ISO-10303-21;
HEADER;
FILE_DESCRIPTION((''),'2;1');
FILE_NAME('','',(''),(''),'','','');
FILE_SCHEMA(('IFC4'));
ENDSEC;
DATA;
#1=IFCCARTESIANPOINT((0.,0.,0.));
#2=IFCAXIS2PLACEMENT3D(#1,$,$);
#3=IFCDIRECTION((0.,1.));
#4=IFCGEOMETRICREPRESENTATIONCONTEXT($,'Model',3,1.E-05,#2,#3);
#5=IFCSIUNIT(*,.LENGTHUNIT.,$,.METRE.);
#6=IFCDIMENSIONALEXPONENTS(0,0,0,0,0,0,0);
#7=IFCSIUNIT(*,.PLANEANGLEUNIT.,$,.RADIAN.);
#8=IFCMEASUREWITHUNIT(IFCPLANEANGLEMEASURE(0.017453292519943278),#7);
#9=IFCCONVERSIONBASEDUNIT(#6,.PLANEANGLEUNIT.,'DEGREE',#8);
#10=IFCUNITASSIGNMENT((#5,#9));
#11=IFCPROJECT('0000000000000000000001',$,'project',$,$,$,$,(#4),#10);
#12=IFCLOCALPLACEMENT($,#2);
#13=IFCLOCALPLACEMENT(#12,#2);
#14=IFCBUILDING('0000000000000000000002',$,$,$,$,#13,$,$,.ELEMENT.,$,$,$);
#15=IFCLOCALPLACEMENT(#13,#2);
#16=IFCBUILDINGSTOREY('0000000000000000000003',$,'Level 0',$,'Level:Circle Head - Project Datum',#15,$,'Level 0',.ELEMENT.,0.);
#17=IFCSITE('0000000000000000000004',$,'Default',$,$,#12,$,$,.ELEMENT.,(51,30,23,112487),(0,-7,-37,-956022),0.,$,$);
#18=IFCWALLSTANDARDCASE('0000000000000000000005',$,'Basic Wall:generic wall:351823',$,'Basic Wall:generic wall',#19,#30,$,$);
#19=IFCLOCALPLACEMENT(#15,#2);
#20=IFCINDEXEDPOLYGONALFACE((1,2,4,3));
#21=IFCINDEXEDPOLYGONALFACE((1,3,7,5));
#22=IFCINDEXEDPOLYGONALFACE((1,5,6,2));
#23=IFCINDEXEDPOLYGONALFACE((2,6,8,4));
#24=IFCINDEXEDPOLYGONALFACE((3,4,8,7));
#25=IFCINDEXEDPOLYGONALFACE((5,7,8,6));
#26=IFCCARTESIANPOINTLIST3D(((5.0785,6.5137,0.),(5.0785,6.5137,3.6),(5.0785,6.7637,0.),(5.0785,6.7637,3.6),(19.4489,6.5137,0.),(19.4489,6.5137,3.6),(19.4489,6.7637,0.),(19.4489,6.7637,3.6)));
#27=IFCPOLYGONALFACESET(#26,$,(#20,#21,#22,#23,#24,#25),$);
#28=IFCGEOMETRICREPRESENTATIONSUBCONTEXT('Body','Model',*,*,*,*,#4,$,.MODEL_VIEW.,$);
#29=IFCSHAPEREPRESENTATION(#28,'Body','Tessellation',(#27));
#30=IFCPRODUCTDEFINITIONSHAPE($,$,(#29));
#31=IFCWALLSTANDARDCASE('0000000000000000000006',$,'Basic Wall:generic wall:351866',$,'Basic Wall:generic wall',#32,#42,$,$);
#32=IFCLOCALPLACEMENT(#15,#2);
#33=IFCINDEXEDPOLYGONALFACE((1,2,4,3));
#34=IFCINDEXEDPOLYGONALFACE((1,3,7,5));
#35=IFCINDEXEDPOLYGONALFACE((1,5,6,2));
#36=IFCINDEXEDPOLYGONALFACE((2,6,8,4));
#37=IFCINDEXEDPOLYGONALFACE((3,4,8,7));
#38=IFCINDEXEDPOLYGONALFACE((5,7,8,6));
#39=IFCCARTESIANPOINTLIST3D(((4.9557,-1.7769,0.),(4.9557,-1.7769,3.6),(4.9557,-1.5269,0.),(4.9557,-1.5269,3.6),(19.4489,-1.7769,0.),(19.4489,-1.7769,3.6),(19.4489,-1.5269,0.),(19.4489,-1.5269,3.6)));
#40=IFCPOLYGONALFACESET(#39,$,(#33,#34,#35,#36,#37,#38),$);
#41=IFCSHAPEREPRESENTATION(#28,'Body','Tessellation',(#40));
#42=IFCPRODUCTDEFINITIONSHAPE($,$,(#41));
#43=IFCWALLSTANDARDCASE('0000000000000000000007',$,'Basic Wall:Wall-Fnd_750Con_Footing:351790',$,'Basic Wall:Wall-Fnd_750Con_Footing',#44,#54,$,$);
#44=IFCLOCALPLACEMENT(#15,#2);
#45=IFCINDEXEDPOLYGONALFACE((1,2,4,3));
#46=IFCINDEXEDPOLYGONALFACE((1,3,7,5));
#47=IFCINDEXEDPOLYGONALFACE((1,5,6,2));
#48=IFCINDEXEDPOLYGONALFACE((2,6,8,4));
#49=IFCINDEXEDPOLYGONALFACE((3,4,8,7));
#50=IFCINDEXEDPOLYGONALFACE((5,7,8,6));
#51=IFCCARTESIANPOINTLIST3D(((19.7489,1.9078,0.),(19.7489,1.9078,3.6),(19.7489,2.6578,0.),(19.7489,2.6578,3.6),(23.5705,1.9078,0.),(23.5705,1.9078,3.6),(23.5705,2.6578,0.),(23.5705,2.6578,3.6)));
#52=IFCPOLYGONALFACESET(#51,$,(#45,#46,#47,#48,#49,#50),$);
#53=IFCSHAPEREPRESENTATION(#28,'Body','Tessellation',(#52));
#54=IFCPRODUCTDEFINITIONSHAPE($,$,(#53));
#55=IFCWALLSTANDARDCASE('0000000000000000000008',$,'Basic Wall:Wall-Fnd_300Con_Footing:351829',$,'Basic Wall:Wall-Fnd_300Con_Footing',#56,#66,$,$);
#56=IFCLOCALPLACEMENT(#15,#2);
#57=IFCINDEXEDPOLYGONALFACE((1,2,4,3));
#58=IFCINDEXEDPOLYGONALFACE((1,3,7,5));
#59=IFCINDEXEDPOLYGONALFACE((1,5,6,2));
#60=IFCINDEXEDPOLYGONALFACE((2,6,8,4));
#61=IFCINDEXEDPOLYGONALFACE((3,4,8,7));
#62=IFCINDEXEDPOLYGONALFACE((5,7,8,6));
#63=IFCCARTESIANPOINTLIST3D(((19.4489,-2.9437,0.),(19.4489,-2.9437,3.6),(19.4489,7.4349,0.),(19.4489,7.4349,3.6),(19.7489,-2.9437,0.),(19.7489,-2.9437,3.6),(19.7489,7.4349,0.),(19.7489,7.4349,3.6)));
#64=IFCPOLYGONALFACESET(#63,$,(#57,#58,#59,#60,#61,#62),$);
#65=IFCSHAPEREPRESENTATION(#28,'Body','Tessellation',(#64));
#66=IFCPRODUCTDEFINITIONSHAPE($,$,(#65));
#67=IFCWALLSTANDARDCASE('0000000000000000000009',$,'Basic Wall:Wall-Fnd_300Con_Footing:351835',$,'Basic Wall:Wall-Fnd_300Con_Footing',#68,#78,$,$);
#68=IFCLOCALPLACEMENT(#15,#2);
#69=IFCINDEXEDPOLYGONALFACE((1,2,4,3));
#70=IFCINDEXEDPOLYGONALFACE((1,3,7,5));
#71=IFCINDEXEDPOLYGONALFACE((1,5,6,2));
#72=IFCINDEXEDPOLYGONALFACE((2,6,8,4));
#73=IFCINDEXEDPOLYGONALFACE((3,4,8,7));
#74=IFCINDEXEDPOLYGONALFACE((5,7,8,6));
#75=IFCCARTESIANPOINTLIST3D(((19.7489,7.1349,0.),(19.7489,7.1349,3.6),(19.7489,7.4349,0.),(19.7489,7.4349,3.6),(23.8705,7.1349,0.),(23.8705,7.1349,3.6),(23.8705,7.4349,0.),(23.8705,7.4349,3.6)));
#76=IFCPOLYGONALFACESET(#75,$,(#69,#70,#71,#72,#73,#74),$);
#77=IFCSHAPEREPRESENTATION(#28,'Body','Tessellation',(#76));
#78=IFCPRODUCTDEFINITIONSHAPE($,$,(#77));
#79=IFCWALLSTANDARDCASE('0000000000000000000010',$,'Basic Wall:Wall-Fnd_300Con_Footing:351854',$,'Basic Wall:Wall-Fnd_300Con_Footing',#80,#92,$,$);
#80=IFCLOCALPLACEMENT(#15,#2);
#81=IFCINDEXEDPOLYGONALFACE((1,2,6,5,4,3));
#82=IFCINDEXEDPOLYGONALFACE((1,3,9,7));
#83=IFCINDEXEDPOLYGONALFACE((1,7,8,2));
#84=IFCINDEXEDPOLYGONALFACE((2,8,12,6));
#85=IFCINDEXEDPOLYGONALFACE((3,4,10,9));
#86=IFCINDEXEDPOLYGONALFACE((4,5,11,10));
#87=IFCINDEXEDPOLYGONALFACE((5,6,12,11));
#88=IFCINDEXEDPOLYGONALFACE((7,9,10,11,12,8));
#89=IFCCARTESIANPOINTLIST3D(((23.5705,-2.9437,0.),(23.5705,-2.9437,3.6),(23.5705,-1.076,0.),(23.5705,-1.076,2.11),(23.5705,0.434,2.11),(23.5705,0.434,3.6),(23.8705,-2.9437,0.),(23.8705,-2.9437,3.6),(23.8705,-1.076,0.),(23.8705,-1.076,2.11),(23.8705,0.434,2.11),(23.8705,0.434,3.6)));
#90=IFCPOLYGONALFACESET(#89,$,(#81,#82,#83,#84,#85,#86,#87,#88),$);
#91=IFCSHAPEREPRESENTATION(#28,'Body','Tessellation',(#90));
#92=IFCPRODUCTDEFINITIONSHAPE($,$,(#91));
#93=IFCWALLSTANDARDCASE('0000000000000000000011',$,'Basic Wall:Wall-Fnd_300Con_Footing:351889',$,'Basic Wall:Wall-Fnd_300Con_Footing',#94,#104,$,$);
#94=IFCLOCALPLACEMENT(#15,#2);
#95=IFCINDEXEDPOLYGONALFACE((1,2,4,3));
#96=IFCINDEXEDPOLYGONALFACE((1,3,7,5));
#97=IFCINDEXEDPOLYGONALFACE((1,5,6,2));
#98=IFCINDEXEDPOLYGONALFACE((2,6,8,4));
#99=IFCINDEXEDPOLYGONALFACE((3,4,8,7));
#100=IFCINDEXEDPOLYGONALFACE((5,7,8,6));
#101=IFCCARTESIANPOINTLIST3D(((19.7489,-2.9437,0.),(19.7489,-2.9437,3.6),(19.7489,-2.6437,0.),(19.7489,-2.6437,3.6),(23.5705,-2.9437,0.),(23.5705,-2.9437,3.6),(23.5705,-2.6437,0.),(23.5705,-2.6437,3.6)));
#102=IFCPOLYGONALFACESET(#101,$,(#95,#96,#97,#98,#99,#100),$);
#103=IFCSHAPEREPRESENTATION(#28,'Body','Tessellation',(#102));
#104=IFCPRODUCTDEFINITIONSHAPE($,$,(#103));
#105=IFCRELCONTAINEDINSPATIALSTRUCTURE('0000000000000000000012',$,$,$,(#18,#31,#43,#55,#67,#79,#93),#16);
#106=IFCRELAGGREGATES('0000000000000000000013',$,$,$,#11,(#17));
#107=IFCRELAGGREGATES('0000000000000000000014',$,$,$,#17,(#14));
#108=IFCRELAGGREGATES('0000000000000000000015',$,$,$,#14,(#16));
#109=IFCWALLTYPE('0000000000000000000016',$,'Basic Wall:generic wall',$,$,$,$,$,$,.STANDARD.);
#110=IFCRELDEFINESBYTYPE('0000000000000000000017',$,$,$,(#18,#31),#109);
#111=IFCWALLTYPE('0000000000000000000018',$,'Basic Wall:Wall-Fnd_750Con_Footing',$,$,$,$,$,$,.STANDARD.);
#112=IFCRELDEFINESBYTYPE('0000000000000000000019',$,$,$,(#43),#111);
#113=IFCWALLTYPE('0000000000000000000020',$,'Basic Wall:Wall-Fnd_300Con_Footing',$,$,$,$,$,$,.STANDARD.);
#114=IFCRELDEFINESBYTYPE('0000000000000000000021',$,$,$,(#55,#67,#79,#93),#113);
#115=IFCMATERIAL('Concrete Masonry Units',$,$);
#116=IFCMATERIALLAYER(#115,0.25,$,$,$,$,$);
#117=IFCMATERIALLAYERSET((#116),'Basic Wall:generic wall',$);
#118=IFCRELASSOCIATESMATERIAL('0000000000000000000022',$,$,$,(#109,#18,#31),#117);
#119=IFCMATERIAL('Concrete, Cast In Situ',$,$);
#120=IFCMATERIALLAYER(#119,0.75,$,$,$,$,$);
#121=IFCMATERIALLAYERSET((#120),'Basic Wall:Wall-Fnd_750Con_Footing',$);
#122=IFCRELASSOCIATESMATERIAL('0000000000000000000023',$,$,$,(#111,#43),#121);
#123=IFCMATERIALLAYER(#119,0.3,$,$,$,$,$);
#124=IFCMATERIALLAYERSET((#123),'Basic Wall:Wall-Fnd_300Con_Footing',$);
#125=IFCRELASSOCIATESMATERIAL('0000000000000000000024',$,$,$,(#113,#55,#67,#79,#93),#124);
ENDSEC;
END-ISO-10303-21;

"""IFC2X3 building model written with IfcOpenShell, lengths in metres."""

from ifc_helpers import new_model, entity, si_unit, converted_unit, direction, frame, frame_2d, origin, place, context, subcontext, project, spatial, rectangle, extrude, material, layer, layer_set, layer_usage, type_object, element, save


model = new_model("IFC2X3")

# Units and contexts
model_context = context("Model", 3, precision=1e-05, world=origin(), true_north=direction((0.0, 1.0)))
body_context = subcontext(model_context, "Body", "Model", "MODEL_VIEW")
ifc_project = project(units=[si_unit("LENGTHUNIT", "METRE"), converted_unit("PLANEANGLEUNIT", "DEGREE", entity("IfcPlaneAngleMeasure", 0.017453292519943278), si_unit("PLANEANGLEUNIT", "RADIAN"), dimensions=[0, 0, 0, 0, 0, 0, 0])], contexts=[model_context])

# Site, building, storey
site_placement = place(None, origin())
site = spatial("IfcSite", under=ifc_project, at=site_placement, Name="Default", CompositionType="ELEMENT", RefLatitude=(51, 30, 23, 112487), RefLongitude=(0, -7, -37, -956022), RefElevation=0.0)
building_placement = place(site_placement, origin())
building = spatial("IfcBuilding", under=site, at=building_placement, CompositionType="ELEMENT")
storey_placement = place(building_placement, origin())
storey = spatial("IfcBuildingStorey", under=building, at=storey_placement, Name="Level 0", ObjectType="Level:Circle Head - Project Datum", LongName="Level 0", CompositionType="ELEMENT", Elevation=0.0)

# Walls
ifc_material_1 = material(Name="Concrete Masonry Units")
ifc_layer_1 = layer(ifc_material_1, 0.25)
ifc_layer_set_1 = layer_set([ifc_layer_1], Name="Basic Wall:generic wall")
ifc_layer_usage_1 = layer_usage(ifc_layer_set_1, "AXIS2", "NEGATIVE", 0.125)
wall_type_1 = type_object("IfcWallType", Name="Basic Wall:generic wall", PredefinedType="STANDARD", material=ifc_layer_set_1)
wall_1_placement = place(storey_placement, frame((19.4489, 6.6387, 0.0), z_axis=(0.0, 0.0, 1.0), x_axis=(-1.0, 0.0, 0.0)))
element("IfcWallStandardCase", 1, at=wall_1_placement, inside=storey, type_object=wall_type_1, material=ifc_layer_usage_1, Name="Basic Wall:generic wall:351823", ObjectType="Basic Wall:generic wall", context=body_context, shape_type="SweptSolid", body=[
    extrude(rectangle(XDim=14.3703, YDim=0.25, at=frame_2d((7.1852, 0.0), x_axis=(-1.0, 0.0))), origin(), (0.0, 0.0, 1.0), 3.6),
])
ifc_layer_usage_2 = layer_usage(ifc_layer_set_1, "AXIS2", "NEGATIVE", 0.125)
wall_2_placement = place(storey_placement, frame((19.4489, -1.6519, 0.0), z_axis=(0.0, 0.0, 1.0), x_axis=(-1.0, 0.0, 0.0)))
element("IfcWallStandardCase", 2, at=wall_2_placement, inside=storey, type_object=wall_type_1, material=ifc_layer_usage_2, Name="Basic Wall:generic wall:351866", ObjectType="Basic Wall:generic wall", context=body_context, shape_type="SweptSolid", body=[
    extrude(rectangle(XDim=14.4932, YDim=0.25, at=frame_2d((7.2466, 0.0), x_axis=(-1.0, 0.0))), origin(), (0.0, 0.0, 1.0), 3.6),
])
ifc_material_2 = material(Name="Concrete, Cast In Situ")
ifc_layer_2 = layer(ifc_material_2, 0.75)
ifc_layer_set_2 = layer_set([ifc_layer_2], Name="Basic Wall:Wall-Fnd_750Con_Footing")
ifc_layer_usage_3 = layer_usage(ifc_layer_set_2, "AXIS2", "NEGATIVE", 0.375)
wall_type_2 = type_object("IfcWallType", Name="Basic Wall:Wall-Fnd_750Con_Footing", PredefinedType="STANDARD", material=ifc_layer_set_2)
wall_3_placement = place(storey_placement, frame((23.5705, 2.2828, 0.0), z_axis=(0.0, 0.0, 1.0), x_axis=(-1.0, 0.0, 0.0)))
element("IfcWallStandardCase", 3, at=wall_3_placement, inside=storey, type_object=wall_type_2, material=ifc_layer_usage_3, Name="Basic Wall:Wall-Fnd_750Con_Footing:351790", ObjectType="Basic Wall:Wall-Fnd_750Con_Footing", context=body_context, shape_type="SweptSolid", body=[
    extrude(rectangle(XDim=3.8216, YDim=0.75, at=frame_2d((1.9108, 0.0), x_axis=(-1.0, 0.0))), origin(), (0.0, 0.0, 1.0), 3.6),
])
ifc_layer_3 = layer(ifc_material_2, 0.3)
ifc_layer_set_3 = layer_set([ifc_layer_3], Name="Basic Wall:Wall-Fnd_300Con_Footing")
ifc_layer_usage_4 = layer_usage(ifc_layer_set_3, "AXIS2", "NEGATIVE", 0.15)
wall_type_3 = type_object("IfcWallType", Name="Basic Wall:Wall-Fnd_300Con_Footing", PredefinedType="STANDARD", material=ifc_layer_set_3)
wall_4_placement = place(storey_placement, frame((19.5989, -2.9437, 0.0), z_axis=(0.0, 0.0, 1.0), x_axis=(0.0, 1.0, 0.0)))
element("IfcWallStandardCase", 4, at=wall_4_placement, inside=storey, type_object=wall_type_3, material=ifc_layer_usage_4, Name="Basic Wall:Wall-Fnd_300Con_Footing:351829", ObjectType="Basic Wall:Wall-Fnd_300Con_Footing", context=body_context, shape_type="SweptSolid", body=[
    extrude(rectangle(XDim=10.3786, YDim=0.3, at=frame_2d((5.1893, 0.0), x_axis=(-1.0, 0.0))), origin(), (0.0, 0.0, 1.0), 3.6),
])
ifc_layer_usage_5 = layer_usage(ifc_layer_set_3, "AXIS2", "NEGATIVE", 0.15)
wall_5_placement = place(storey_placement, frame((19.7489, 7.2849, 0.0)))
element("IfcWallStandardCase", 5, at=wall_5_placement, inside=storey, type_object=wall_type_3, material=ifc_layer_usage_5, Name="Basic Wall:Wall-Fnd_300Con_Footing:351835", ObjectType="Basic Wall:Wall-Fnd_300Con_Footing", context=body_context, shape_type="SweptSolid", body=[
    extrude(rectangle(XDim=4.1216, YDim=0.3, at=frame_2d((2.0608, 0.0), x_axis=(-1.0, 0.0))), origin(), (0.0, 0.0, 1.0), 3.6),
])

# Wall, opening
ifc_layer_usage_6 = layer_usage(ifc_layer_set_3, "AXIS2", "NEGATIVE", 0.15)
wall_6_placement = place(storey_placement, frame((23.7205, 0.434, 0.0), z_axis=(0.0, 0.0, 1.0), x_axis=(0.0, -1.0, 0.0)))
wall_6 = element("IfcWallStandardCase", 6, at=wall_6_placement, inside=storey, type_object=wall_type_3, material=ifc_layer_usage_6, Name="Basic Wall:Wall-Fnd_300Con_Footing:351854", ObjectType="Basic Wall:Wall-Fnd_300Con_Footing", context=body_context, shape_type="SweptSolid", body=[
    extrude(rectangle(XDim=3.3776, YDim=0.3, at=frame_2d((1.6888, 0.0), x_axis=(-1.0, 0.0))), origin(), (0.0, 0.0, 1.0), 3.6),
])
opening_1_placement = place(wall_6_placement, frame((1.51, 0.15, 0.0)))
element("IfcOpeningElement", 7, at=opening_1_placement, cuts=wall_6, ObjectType="Opening", context=body_context, shape_type="SweptSolid", body=[
    extrude(rectangle(XDim=2.11, YDim=1.81, at=frame_2d((1.055, 0.905), x_axis=(-1.0, 0.0))), frame((0.0, 0.0, 0.0), z_axis=(0.0, -1.0, 0.0), x_axis=(0.0, 0.0, 1.0)), (0.0, 0.0, 1.0), 0.3),
])

# Wall
ifc_layer_usage_7 = layer_usage(ifc_layer_set_3, "AXIS2", "NEGATIVE", 0.15)
wall_7_placement = place(storey_placement, frame((23.5705, -2.7937, 0.0), z_axis=(0.0, 0.0, 1.0), x_axis=(-1.0, 0.0, 0.0)))
element("IfcWallStandardCase", 8, at=wall_7_placement, inside=storey, type_object=wall_type_3, material=ifc_layer_usage_7, Name="Basic Wall:Wall-Fnd_300Con_Footing:351889", ObjectType="Basic Wall:Wall-Fnd_300Con_Footing", context=body_context, shape_type="SweptSolid", body=[
    extrude(rectangle(XDim=3.8216, YDim=0.3, at=frame_2d((1.9108, 0.0), x_axis=(-1.0, 0.0))), origin(), (0.0, 0.0, 1.0), 3.6),
])

save(model, "model.ifc")
